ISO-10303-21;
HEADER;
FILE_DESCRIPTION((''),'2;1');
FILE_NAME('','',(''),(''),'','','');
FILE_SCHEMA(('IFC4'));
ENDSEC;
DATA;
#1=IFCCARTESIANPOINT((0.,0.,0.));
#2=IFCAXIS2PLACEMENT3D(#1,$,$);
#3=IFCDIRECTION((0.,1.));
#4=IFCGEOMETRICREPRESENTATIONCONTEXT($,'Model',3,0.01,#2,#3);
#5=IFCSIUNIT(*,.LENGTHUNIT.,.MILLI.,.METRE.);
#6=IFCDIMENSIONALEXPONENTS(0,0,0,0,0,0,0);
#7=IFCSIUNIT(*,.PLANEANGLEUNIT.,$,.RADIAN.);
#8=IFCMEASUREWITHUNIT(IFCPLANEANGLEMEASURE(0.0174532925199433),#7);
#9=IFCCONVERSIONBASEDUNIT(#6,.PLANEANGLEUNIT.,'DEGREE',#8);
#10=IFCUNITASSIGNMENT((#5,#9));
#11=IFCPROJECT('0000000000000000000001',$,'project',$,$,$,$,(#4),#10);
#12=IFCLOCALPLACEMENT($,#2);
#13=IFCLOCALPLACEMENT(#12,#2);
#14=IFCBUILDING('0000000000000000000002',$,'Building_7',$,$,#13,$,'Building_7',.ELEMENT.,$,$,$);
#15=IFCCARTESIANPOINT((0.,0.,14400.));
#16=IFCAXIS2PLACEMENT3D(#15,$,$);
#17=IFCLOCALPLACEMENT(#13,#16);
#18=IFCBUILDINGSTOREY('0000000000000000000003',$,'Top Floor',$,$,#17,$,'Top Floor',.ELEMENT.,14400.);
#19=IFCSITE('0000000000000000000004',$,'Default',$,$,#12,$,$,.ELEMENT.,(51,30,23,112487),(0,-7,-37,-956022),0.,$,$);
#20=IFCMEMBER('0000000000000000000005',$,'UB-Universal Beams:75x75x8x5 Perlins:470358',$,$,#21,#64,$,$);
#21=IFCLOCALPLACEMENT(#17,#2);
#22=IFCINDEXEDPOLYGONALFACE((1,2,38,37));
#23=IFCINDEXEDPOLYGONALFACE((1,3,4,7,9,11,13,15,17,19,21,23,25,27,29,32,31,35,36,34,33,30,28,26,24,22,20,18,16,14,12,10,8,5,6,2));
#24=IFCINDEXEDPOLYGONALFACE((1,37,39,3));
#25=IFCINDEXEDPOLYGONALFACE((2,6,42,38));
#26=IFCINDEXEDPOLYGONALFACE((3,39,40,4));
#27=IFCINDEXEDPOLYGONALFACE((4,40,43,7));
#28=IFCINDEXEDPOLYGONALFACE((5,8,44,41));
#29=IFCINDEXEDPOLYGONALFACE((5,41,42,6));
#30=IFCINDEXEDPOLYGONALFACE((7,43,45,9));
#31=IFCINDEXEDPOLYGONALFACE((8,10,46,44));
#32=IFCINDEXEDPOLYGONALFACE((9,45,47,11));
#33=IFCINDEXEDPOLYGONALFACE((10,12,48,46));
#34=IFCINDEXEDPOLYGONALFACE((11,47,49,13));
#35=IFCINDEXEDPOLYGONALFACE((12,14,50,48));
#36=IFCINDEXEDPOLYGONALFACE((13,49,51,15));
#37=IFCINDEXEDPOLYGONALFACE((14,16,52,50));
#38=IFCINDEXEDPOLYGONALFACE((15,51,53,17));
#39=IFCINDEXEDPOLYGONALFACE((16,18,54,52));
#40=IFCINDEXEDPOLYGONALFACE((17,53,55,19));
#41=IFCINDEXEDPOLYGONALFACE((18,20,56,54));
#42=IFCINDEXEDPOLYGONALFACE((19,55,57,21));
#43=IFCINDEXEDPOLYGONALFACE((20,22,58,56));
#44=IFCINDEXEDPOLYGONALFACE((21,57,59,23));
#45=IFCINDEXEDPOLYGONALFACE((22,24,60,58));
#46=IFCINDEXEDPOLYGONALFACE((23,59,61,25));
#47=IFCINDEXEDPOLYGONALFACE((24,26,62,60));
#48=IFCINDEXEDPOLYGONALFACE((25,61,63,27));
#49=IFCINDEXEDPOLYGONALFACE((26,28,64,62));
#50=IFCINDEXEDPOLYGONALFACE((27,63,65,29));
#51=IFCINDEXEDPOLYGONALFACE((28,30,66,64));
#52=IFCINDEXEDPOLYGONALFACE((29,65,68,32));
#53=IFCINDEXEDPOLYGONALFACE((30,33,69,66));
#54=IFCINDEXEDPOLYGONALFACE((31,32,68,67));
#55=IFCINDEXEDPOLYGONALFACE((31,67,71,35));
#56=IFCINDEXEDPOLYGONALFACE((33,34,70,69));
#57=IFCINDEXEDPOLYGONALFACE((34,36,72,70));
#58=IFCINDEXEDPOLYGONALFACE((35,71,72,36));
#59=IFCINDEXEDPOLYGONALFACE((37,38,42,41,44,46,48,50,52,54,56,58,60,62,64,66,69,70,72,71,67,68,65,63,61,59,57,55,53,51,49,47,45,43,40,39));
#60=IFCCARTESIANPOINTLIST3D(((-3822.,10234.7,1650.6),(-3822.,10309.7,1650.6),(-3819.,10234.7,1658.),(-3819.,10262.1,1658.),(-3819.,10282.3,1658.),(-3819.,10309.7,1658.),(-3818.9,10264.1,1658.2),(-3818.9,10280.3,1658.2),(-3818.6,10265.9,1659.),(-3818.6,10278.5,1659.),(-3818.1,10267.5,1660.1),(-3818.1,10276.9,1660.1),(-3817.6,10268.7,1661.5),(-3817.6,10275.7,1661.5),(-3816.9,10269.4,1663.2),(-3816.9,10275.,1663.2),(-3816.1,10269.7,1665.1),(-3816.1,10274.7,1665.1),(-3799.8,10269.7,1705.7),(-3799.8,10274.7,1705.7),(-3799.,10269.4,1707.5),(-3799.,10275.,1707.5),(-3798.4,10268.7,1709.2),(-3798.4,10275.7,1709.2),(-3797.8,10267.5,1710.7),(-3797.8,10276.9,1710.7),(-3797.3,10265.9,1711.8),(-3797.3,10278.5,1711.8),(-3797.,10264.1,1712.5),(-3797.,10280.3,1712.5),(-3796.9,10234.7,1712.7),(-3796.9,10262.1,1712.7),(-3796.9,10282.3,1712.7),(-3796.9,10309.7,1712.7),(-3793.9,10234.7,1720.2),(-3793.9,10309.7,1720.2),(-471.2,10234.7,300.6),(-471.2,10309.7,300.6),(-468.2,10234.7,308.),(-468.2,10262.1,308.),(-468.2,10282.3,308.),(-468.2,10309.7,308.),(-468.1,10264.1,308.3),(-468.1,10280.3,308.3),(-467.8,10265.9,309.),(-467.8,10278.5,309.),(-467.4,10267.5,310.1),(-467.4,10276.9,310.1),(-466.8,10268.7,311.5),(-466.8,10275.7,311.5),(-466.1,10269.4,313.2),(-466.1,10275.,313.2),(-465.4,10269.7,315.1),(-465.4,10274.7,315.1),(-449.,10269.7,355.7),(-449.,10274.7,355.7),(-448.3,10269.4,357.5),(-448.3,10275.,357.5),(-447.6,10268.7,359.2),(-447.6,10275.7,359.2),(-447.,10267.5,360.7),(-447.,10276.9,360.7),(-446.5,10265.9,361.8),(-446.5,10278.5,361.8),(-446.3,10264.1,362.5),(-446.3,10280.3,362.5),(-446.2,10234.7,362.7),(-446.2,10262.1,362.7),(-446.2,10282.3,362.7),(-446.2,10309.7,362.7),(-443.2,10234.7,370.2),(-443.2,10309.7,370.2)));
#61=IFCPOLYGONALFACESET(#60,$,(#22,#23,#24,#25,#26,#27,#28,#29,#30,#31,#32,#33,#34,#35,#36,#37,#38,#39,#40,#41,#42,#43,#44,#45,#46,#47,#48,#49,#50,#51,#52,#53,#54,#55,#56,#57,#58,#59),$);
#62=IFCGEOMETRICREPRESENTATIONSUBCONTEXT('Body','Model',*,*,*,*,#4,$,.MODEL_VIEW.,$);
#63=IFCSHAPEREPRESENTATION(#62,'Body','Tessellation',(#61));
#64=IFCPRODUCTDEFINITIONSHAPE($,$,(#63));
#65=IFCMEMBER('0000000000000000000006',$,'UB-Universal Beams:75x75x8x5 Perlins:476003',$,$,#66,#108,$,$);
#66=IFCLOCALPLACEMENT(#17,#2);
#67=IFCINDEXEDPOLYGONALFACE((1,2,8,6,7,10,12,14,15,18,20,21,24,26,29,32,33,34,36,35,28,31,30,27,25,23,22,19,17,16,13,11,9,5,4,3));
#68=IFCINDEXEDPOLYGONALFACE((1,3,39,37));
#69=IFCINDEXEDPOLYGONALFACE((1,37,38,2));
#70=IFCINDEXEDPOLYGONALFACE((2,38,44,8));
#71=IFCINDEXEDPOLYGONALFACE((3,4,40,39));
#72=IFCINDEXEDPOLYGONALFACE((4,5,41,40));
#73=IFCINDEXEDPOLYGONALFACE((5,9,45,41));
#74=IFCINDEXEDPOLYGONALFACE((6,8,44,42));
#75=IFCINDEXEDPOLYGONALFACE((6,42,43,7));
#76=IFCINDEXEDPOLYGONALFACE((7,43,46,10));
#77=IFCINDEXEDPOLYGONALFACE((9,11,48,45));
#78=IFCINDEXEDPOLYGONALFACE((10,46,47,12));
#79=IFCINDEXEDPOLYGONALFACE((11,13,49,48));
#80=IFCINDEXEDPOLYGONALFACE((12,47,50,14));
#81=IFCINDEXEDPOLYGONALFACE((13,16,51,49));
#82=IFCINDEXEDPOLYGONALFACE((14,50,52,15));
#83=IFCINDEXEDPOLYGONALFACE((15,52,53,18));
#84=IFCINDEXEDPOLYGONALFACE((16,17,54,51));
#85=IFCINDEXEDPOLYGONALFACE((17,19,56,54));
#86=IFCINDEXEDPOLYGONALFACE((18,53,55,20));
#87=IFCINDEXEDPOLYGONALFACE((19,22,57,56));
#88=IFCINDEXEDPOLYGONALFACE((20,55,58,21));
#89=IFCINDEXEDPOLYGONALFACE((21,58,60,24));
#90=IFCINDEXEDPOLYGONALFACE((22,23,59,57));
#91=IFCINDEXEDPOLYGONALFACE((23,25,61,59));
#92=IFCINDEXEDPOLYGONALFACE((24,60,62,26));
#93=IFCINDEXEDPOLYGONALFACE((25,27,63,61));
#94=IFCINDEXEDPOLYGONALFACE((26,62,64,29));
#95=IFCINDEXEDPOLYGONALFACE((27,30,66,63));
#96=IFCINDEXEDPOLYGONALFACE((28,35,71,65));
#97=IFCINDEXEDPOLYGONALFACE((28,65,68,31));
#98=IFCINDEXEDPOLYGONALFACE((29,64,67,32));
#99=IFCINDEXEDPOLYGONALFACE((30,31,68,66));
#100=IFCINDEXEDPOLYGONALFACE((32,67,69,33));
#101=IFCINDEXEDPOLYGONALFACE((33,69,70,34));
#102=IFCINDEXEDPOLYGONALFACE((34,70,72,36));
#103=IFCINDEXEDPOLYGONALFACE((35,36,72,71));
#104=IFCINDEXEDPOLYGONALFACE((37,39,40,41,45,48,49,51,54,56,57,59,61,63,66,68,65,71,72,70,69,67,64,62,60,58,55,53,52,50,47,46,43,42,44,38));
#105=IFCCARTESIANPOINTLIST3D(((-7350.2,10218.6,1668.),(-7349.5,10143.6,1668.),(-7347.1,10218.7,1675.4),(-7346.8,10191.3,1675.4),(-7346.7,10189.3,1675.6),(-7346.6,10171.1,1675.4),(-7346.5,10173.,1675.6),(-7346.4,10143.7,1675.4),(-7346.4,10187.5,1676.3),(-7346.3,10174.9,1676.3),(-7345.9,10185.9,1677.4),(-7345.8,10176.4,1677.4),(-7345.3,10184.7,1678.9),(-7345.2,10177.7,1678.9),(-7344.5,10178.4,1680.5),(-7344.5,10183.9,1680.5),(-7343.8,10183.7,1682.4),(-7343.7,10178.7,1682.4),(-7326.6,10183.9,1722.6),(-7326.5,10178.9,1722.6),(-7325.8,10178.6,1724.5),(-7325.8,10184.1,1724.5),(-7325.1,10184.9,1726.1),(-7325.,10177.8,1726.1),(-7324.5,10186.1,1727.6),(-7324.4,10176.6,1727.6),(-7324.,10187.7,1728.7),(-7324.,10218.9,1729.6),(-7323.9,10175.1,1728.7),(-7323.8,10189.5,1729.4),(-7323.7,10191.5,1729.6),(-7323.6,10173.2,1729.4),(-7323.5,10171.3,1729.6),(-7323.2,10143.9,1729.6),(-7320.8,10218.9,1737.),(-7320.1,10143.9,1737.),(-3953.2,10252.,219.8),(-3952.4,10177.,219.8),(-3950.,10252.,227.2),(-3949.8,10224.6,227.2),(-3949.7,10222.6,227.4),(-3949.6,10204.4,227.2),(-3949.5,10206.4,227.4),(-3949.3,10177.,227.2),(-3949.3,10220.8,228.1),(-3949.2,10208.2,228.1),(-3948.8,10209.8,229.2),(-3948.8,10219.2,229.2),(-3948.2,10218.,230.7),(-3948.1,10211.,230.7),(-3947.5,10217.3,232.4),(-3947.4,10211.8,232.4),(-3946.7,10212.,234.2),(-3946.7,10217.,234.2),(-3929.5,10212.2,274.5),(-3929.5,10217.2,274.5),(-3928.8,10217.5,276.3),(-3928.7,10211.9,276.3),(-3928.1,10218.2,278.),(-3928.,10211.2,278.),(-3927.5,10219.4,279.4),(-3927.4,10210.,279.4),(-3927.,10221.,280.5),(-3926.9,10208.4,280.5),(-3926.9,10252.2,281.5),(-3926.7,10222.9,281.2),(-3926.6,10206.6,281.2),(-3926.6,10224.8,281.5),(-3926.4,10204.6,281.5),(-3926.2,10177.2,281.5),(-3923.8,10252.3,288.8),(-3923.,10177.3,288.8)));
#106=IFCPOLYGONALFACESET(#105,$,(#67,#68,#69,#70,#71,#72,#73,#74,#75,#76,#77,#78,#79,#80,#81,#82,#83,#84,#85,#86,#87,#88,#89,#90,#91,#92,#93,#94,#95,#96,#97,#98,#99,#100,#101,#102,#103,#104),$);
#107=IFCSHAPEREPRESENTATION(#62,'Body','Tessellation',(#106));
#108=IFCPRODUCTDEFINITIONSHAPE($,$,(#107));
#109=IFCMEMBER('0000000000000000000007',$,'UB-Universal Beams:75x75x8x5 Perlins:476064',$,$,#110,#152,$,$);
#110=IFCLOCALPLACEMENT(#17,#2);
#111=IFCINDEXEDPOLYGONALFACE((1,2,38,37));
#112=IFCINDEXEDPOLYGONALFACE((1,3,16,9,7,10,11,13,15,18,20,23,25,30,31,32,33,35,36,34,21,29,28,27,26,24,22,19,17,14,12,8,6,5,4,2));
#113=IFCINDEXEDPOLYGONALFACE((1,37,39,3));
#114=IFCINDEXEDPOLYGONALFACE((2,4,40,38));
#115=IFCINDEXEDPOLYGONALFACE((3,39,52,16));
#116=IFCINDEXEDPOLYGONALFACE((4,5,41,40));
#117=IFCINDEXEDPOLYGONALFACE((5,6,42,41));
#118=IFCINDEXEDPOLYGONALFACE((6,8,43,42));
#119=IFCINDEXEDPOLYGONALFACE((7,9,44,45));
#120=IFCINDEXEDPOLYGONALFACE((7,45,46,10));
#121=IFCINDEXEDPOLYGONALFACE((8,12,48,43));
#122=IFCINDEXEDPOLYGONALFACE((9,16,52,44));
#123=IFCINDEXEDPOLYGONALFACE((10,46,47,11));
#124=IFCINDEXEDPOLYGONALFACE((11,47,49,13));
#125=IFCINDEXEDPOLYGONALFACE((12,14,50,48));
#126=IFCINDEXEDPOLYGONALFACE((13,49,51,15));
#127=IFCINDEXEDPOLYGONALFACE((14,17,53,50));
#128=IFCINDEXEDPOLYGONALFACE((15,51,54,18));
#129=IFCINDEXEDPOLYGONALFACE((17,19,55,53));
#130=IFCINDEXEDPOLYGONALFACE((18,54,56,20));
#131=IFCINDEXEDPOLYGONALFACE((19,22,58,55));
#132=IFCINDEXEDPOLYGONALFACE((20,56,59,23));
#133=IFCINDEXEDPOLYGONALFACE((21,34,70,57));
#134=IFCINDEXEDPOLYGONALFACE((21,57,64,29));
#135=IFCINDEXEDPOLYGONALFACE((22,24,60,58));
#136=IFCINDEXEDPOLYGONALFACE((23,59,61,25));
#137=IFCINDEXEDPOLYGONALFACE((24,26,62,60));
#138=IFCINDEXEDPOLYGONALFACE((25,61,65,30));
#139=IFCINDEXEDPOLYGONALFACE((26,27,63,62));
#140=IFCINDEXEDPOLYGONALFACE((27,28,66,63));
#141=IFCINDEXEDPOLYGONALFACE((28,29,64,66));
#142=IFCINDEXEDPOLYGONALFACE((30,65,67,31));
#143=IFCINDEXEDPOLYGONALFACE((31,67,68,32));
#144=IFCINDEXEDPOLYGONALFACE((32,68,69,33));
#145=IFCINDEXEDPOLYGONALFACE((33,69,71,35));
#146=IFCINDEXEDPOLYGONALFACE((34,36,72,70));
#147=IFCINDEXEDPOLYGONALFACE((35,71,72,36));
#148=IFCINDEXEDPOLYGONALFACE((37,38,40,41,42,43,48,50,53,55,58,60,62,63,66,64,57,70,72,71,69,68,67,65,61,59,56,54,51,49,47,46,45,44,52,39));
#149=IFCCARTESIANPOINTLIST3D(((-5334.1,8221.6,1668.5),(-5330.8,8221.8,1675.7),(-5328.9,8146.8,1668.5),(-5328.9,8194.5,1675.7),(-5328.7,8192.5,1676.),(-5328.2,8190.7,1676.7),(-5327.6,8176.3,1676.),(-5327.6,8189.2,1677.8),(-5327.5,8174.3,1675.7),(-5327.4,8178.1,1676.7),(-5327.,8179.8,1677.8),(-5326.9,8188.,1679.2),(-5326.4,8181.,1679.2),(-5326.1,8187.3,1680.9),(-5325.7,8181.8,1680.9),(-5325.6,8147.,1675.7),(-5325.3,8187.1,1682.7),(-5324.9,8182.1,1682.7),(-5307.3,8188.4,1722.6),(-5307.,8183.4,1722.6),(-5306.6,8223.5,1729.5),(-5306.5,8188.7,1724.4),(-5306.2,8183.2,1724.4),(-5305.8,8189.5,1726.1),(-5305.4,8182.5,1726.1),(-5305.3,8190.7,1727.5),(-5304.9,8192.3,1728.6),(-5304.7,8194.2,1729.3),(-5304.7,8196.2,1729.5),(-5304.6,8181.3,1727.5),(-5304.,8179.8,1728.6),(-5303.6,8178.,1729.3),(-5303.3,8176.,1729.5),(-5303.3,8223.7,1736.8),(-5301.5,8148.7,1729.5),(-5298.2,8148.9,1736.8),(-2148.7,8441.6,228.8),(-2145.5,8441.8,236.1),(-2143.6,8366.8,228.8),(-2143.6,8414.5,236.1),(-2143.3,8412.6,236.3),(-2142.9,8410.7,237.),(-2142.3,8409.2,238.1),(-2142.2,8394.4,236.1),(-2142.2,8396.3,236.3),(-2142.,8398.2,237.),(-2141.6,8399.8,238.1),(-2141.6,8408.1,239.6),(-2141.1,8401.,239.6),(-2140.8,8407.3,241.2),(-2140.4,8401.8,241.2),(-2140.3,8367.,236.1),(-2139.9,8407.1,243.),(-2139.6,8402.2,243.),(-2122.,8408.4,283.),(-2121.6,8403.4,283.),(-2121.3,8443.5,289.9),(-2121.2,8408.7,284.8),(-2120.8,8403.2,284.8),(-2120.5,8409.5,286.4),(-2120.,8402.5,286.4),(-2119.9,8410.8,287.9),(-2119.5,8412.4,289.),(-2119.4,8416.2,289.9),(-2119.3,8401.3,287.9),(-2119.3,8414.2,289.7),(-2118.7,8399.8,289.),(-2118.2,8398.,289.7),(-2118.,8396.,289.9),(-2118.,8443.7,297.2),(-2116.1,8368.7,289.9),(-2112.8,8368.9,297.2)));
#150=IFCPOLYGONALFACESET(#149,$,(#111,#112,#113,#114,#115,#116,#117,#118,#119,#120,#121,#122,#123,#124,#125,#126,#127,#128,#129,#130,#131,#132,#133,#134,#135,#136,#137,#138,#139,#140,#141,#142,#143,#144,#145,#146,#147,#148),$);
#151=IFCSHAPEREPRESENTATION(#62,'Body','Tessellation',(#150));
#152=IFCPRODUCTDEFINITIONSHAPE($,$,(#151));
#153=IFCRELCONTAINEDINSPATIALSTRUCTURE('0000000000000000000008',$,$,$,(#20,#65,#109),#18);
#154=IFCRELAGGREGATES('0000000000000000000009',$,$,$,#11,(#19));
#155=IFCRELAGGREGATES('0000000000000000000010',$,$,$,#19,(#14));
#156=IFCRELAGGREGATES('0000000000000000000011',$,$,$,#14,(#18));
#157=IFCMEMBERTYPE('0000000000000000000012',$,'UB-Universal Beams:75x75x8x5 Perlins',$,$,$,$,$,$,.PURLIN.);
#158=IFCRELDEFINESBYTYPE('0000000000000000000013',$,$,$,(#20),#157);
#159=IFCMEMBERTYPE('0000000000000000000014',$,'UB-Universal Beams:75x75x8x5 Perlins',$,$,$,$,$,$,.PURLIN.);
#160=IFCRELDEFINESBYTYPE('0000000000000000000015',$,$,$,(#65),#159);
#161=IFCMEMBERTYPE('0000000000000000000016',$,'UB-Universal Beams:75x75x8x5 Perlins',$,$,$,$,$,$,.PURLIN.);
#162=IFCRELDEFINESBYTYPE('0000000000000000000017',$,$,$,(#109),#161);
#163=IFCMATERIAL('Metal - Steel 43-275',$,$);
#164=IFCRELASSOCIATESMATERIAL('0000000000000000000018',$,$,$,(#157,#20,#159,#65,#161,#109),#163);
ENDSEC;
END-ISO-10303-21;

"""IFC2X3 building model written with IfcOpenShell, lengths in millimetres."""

from ifc_helpers import new_model, entity, si_unit, converted_unit, direction, frame, frame_2d, origin, place, context, subcontext, project, spatial, polyline, circle_curve, parameter, trimmed, segment, composite_curve, outline, extrude, source, transform, mapped, material, type_object, type_shapes, element, save


model = new_model("IFC2X3")

# Units and contexts
model_context = context("Model", 3, precision=0.01, world=origin(), true_north=direction((0.0, 1.0)))
body_context = subcontext(model_context, "Body", "Model", "MODEL_VIEW")
ifc_project = project(units=[si_unit("LENGTHUNIT", "METRE", prefix="MILLI"), converted_unit("PLANEANGLEUNIT", "DEGREE", entity("IfcPlaneAngleMeasure", 0.0174532925199433), si_unit("PLANEANGLEUNIT", "RADIAN"), dimensions=[0, 0, 0, 0, 0, 0, 0])], contexts=[model_context])

# Site, building, storey
site_placement = place(None, origin())
site = spatial("IfcSite", under=ifc_project, at=site_placement, Name="Default", CompositionType="ELEMENT", RefLatitude=(51, 30, 23, 112487), RefLongitude=(0, -7, -37, -956022), RefElevation=0.0)
building_placement = place(site_placement, origin())
building = spatial("IfcBuilding", under=site, at=building_placement, Name="Building_7", LongName="Building_7", CompositionType="ELEMENT")
storey_placement = place(building_placement, frame((0.0, 0.0, 14400.0)))
storey = spatial("IfcBuildingStorey", under=building, at=storey_placement, Name="Top Floor", LongName="Top Floor", CompositionType="ELEMENT", Elevation=14400.0)

# Members
ifc_material = material(Name="Metal - Steel 43-275")
member_type_1 = type_object("IfcMemberType", Name="UB-Universal Beams:75x75x8x5 Perlins", PredefinedType="PURLIN", material=ifc_material)
shared_shape_1 = source(origin(), body_context, "Body", "SweptSolid", [
    extrude(outline(composite_curve([segment(polyline([(-37.5, -29.5), (-37.5, -37.5)]), True, "CONTINUOUS"), segment(polyline([(-37.5, -37.5), (37.5, -37.5)]), True, "CONTINUOUS"), segment(polyline([(37.5, -37.5), (37.5, -29.5)]), True, "CONTINUOUS"), segment(polyline([(37.5, -29.5), (10.1, -29.5)]), True, "CONTINUOUS"), segment(trimmed(circle_curve(frame_2d((10.1, -21.9), x_axis=(1.0, 0.0)), 7.6), [parameter(180.0)], [parameter(270.0)], True, "PARAMETER"), False, "CONTINUOUS"), segment(polyline([(2.5, -21.9), (2.5, 21.9)]), True, "CONTINUOUS"), segment(trimmed(circle_curve(frame_2d((10.1, 21.9), x_axis=(1.0, 0.0)), 7.6), [parameter(90.0)], [parameter(180.0)], True, "PARAMETER"), False, "CONTINUOUS"), segment(polyline([(10.1, 29.5), (37.5, 29.5)]), True, "CONTINUOUS"), segment(polyline([(37.5, 29.5), (37.5, 37.5)]), True, "CONTINUOUS"), segment(polyline([(37.5, 37.5), (-37.5, 37.5)]), True, "CONTINUOUS"), segment(polyline([(-37.5, 37.5), (-37.5, 29.5)]), True, "CONTINUOUS"), segment(polyline([(-37.5, 29.5), (-10.1, 29.5)]), True, "CONTINUOUS"), segment(trimmed(circle_curve(frame_2d((-10.1, 21.9), x_axis=(1.0, 0.0)), 7.6), [parameter(360.0)], [parameter(90.0)], True, "PARAMETER"), False, "CONTINUOUS"), segment(polyline([(-2.5, 21.9), (-2.5, -21.9)]), True, "CONTINUOUS"), segment(trimmed(circle_curve(frame_2d((-10.1, -21.9), x_axis=(1.0, 0.0)), 7.6), [parameter(270.0)], [parameter(360.0)], True, "PARAMETER"), False, "CONTINUOUS"), segment(polyline([(-10.1, -29.5), (-37.5, -29.5)]), True, "CONTINUOUS")], self_intersect=False)), frame((-1847.8, 0.0, 0.0), z_axis=(-1.0, 0.0, 0.0), x_axis=(0.0, -1.0, 0.0)), (0.0, 0.0, -1.0), 3612.5),
])
type_shapes(member_type_1, [shared_shape_1])
member_1_placement = place(storey_placement, frame((-2094.0, 10272.2, 994.8), z_axis=(0.373701, 0.0, 0.927549), x_axis=(0.927549, 0.0, -0.373701)))
element("IfcMember", 1, at=member_1_placement, inside=storey, type_object=member_type_1, material=ifc_material, Name="UB-Universal Beams:75x75x8x5 Perlins:470358", context=body_context, shape_type="MappedRepresentation", body=[
    mapped(shared_shape_1, transform((0.0, 0.0, 0.0), scale=1.0)),
])
member_type_2 = type_object("IfcMemberType", Name="UB-Universal Beams:75x75x8x5 Perlins", PredefinedType="PURLIN", material=ifc_material)
shared_shape_2 = source(origin(), body_context, "Body", "SweptSolid", [
    extrude(outline(composite_curve([segment(polyline([(-37.5, -29.5), (-37.5, -37.5)]), True, "CONTINUOUS"), segment(polyline([(-37.5, -37.5), (37.5, -37.5)]), True, "CONTINUOUS"), segment(polyline([(37.5, -37.5), (37.5, -29.5)]), True, "CONTINUOUS"), segment(polyline([(37.5, -29.5), (10.1, -29.5)]), True, "CONTINUOUS"), segment(trimmed(circle_curve(frame_2d((10.1, -21.9), x_axis=(1.0, 0.0)), 7.6), [parameter(180.0)], [parameter(270.0)], True, "PARAMETER"), False, "CONTINUOUS"), segment(polyline([(2.5, -21.9), (2.5, 21.9)]), True, "CONTINUOUS"), segment(trimmed(circle_curve(frame_2d((10.1, 21.9), x_axis=(1.0, 0.0)), 7.6), [parameter(90.0)], [parameter(180.0)], True, "PARAMETER"), False, "CONTINUOUS"), segment(polyline([(10.1, 29.5), (37.5, 29.5)]), True, "CONTINUOUS"), segment(polyline([(37.5, 29.5), (37.5, 37.5)]), True, "CONTINUOUS"), segment(polyline([(37.5, 37.5), (-37.5, 37.5)]), True, "CONTINUOUS"), segment(polyline([(-37.5, 37.5), (-37.5, 29.5)]), True, "CONTINUOUS"), segment(polyline([(-37.5, 29.5), (-10.1, 29.5)]), True, "CONTINUOUS"), segment(trimmed(circle_curve(frame_2d((-10.1, 21.9), x_axis=(1.0, 0.0)), 7.6), [parameter(360.0)], [parameter(90.0)], True, "PARAMETER"), False, "CONTINUOUS"), segment(polyline([(-2.5, 21.9), (-2.5, -21.9)]), True, "CONTINUOUS"), segment(trimmed(circle_curve(frame_2d((-10.1, -21.9), x_axis=(1.0, 0.0)), 7.6), [parameter(270.0)], [parameter(360.0)], True, "PARAMETER"), False, "CONTINUOUS"), segment(polyline([(-10.1, -29.5), (-37.5, -29.5)]), True, "CONTINUOUS")], self_intersect=False)), frame((-1828.3, 0.0, 0.0), z_axis=(-1.0, 0.0, 0.0), x_axis=(0.0, -1.0, 0.0)), (0.0, 0.0, -1.0), 3693.0),
])
type_shapes(member_type_2, [shared_shape_2])
member_2_placement = place(storey_placement, frame((-5619.9, 10198.1, 971.3), z_axis=(0.39212, 0.003849, 0.919906), x_axis=(-0.919862, -0.009029, 0.392139)))
element("IfcMember", 2, at=member_2_placement, inside=storey, type_object=member_type_2, material=ifc_material, Name="UB-Universal Beams:75x75x8x5 Perlins:476003", context=body_context, shape_type="MappedRepresentation", body=[
    mapped(shared_shape_2, transform((0.0, 0.0, 0.0), scale=1.0)),
])
member_type_3 = type_object("IfcMemberType", Name="UB-Universal Beams:75x75x8x5 Perlins", PredefinedType="PURLIN", material=ifc_material)
shared_shape_3 = source(origin(), body_context, "Body", "SweptSolid", [
    extrude(outline(composite_curve([segment(polyline([(-37.5, -29.5), (-37.5, -37.5)]), True, "CONTINUOUS"), segment(polyline([(-37.5, -37.5), (37.5, -37.5)]), True, "CONTINUOUS"), segment(polyline([(37.5, -37.5), (37.5, -29.5)]), True, "CONTINUOUS"), segment(polyline([(37.5, -29.5), (10.1, -29.5)]), True, "CONTINUOUS"), segment(trimmed(circle_curve(frame_2d((10.1, -21.9), x_axis=(1.0, 0.0)), 7.6), [parameter(180.0)], [parameter(270.0)], True, "PARAMETER"), False, "CONTINUOUS"), segment(polyline([(2.5, -21.9), (2.5, 21.9)]), True, "CONTINUOUS"), segment(trimmed(circle_curve(frame_2d((10.1, 21.9), x_axis=(1.0, 0.0)), 7.6), [parameter(90.0)], [parameter(180.0)], True, "PARAMETER"), False, "CONTINUOUS"), segment(polyline([(10.1, 29.5), (37.5, 29.5)]), True, "CONTINUOUS"), segment(polyline([(37.5, 29.5), (37.5, 37.5)]), True, "CONTINUOUS"), segment(polyline([(37.5, 37.5), (-37.5, 37.5)]), True, "CONTINUOUS"), segment(polyline([(-37.5, 37.5), (-37.5, 29.5)]), True, "CONTINUOUS"), segment(polyline([(-37.5, 29.5), (-10.1, 29.5)]), True, "CONTINUOUS"), segment(trimmed(circle_curve(frame_2d((-10.1, 21.9), x_axis=(1.0, 0.0)), 7.6), [parameter(360.0)], [parameter(90.0)], True, "PARAMETER"), False, "CONTINUOUS"), segment(polyline([(-2.5, 21.9), (-2.5, -21.9)]), True, "CONTINUOUS"), segment(trimmed(circle_curve(frame_2d((-10.1, -21.9), x_axis=(1.0, 0.0)), 7.6), [parameter(270.0)], [parameter(360.0)], True, "PARAMETER"), False, "CONTINUOUS"), segment(polyline([(-10.1, -29.5), (-37.5, -29.5)]), True, "CONTINUOUS")], self_intersect=False)), frame((-1744.7, 0.0, 0.0), z_axis=(-1.0, 0.0, 0.0), x_axis=(0.0, -1.0, 0.0)), (0.0, 0.0, -1.0), 3502.5),
])
type_shapes(member_type_3, [shared_shape_3])
member_3_placement = place(storey_placement, frame((-3717.5, 8295.7, 980.1), z_axis=(0.410056, 0.028324, 0.91162), x_axis=(-0.909453, -0.06282, 0.411033)))
element("IfcMember", 3, at=member_3_placement, inside=storey, type_object=member_type_3, material=ifc_material, Name="UB-Universal Beams:75x75x8x5 Perlins:476064", context=body_context, shape_type="MappedRepresentation", body=[
    mapped(shared_shape_3, transform((0.0, 0.0, 0.0), scale=1.0)),
])

save(model, "model.ifc")
